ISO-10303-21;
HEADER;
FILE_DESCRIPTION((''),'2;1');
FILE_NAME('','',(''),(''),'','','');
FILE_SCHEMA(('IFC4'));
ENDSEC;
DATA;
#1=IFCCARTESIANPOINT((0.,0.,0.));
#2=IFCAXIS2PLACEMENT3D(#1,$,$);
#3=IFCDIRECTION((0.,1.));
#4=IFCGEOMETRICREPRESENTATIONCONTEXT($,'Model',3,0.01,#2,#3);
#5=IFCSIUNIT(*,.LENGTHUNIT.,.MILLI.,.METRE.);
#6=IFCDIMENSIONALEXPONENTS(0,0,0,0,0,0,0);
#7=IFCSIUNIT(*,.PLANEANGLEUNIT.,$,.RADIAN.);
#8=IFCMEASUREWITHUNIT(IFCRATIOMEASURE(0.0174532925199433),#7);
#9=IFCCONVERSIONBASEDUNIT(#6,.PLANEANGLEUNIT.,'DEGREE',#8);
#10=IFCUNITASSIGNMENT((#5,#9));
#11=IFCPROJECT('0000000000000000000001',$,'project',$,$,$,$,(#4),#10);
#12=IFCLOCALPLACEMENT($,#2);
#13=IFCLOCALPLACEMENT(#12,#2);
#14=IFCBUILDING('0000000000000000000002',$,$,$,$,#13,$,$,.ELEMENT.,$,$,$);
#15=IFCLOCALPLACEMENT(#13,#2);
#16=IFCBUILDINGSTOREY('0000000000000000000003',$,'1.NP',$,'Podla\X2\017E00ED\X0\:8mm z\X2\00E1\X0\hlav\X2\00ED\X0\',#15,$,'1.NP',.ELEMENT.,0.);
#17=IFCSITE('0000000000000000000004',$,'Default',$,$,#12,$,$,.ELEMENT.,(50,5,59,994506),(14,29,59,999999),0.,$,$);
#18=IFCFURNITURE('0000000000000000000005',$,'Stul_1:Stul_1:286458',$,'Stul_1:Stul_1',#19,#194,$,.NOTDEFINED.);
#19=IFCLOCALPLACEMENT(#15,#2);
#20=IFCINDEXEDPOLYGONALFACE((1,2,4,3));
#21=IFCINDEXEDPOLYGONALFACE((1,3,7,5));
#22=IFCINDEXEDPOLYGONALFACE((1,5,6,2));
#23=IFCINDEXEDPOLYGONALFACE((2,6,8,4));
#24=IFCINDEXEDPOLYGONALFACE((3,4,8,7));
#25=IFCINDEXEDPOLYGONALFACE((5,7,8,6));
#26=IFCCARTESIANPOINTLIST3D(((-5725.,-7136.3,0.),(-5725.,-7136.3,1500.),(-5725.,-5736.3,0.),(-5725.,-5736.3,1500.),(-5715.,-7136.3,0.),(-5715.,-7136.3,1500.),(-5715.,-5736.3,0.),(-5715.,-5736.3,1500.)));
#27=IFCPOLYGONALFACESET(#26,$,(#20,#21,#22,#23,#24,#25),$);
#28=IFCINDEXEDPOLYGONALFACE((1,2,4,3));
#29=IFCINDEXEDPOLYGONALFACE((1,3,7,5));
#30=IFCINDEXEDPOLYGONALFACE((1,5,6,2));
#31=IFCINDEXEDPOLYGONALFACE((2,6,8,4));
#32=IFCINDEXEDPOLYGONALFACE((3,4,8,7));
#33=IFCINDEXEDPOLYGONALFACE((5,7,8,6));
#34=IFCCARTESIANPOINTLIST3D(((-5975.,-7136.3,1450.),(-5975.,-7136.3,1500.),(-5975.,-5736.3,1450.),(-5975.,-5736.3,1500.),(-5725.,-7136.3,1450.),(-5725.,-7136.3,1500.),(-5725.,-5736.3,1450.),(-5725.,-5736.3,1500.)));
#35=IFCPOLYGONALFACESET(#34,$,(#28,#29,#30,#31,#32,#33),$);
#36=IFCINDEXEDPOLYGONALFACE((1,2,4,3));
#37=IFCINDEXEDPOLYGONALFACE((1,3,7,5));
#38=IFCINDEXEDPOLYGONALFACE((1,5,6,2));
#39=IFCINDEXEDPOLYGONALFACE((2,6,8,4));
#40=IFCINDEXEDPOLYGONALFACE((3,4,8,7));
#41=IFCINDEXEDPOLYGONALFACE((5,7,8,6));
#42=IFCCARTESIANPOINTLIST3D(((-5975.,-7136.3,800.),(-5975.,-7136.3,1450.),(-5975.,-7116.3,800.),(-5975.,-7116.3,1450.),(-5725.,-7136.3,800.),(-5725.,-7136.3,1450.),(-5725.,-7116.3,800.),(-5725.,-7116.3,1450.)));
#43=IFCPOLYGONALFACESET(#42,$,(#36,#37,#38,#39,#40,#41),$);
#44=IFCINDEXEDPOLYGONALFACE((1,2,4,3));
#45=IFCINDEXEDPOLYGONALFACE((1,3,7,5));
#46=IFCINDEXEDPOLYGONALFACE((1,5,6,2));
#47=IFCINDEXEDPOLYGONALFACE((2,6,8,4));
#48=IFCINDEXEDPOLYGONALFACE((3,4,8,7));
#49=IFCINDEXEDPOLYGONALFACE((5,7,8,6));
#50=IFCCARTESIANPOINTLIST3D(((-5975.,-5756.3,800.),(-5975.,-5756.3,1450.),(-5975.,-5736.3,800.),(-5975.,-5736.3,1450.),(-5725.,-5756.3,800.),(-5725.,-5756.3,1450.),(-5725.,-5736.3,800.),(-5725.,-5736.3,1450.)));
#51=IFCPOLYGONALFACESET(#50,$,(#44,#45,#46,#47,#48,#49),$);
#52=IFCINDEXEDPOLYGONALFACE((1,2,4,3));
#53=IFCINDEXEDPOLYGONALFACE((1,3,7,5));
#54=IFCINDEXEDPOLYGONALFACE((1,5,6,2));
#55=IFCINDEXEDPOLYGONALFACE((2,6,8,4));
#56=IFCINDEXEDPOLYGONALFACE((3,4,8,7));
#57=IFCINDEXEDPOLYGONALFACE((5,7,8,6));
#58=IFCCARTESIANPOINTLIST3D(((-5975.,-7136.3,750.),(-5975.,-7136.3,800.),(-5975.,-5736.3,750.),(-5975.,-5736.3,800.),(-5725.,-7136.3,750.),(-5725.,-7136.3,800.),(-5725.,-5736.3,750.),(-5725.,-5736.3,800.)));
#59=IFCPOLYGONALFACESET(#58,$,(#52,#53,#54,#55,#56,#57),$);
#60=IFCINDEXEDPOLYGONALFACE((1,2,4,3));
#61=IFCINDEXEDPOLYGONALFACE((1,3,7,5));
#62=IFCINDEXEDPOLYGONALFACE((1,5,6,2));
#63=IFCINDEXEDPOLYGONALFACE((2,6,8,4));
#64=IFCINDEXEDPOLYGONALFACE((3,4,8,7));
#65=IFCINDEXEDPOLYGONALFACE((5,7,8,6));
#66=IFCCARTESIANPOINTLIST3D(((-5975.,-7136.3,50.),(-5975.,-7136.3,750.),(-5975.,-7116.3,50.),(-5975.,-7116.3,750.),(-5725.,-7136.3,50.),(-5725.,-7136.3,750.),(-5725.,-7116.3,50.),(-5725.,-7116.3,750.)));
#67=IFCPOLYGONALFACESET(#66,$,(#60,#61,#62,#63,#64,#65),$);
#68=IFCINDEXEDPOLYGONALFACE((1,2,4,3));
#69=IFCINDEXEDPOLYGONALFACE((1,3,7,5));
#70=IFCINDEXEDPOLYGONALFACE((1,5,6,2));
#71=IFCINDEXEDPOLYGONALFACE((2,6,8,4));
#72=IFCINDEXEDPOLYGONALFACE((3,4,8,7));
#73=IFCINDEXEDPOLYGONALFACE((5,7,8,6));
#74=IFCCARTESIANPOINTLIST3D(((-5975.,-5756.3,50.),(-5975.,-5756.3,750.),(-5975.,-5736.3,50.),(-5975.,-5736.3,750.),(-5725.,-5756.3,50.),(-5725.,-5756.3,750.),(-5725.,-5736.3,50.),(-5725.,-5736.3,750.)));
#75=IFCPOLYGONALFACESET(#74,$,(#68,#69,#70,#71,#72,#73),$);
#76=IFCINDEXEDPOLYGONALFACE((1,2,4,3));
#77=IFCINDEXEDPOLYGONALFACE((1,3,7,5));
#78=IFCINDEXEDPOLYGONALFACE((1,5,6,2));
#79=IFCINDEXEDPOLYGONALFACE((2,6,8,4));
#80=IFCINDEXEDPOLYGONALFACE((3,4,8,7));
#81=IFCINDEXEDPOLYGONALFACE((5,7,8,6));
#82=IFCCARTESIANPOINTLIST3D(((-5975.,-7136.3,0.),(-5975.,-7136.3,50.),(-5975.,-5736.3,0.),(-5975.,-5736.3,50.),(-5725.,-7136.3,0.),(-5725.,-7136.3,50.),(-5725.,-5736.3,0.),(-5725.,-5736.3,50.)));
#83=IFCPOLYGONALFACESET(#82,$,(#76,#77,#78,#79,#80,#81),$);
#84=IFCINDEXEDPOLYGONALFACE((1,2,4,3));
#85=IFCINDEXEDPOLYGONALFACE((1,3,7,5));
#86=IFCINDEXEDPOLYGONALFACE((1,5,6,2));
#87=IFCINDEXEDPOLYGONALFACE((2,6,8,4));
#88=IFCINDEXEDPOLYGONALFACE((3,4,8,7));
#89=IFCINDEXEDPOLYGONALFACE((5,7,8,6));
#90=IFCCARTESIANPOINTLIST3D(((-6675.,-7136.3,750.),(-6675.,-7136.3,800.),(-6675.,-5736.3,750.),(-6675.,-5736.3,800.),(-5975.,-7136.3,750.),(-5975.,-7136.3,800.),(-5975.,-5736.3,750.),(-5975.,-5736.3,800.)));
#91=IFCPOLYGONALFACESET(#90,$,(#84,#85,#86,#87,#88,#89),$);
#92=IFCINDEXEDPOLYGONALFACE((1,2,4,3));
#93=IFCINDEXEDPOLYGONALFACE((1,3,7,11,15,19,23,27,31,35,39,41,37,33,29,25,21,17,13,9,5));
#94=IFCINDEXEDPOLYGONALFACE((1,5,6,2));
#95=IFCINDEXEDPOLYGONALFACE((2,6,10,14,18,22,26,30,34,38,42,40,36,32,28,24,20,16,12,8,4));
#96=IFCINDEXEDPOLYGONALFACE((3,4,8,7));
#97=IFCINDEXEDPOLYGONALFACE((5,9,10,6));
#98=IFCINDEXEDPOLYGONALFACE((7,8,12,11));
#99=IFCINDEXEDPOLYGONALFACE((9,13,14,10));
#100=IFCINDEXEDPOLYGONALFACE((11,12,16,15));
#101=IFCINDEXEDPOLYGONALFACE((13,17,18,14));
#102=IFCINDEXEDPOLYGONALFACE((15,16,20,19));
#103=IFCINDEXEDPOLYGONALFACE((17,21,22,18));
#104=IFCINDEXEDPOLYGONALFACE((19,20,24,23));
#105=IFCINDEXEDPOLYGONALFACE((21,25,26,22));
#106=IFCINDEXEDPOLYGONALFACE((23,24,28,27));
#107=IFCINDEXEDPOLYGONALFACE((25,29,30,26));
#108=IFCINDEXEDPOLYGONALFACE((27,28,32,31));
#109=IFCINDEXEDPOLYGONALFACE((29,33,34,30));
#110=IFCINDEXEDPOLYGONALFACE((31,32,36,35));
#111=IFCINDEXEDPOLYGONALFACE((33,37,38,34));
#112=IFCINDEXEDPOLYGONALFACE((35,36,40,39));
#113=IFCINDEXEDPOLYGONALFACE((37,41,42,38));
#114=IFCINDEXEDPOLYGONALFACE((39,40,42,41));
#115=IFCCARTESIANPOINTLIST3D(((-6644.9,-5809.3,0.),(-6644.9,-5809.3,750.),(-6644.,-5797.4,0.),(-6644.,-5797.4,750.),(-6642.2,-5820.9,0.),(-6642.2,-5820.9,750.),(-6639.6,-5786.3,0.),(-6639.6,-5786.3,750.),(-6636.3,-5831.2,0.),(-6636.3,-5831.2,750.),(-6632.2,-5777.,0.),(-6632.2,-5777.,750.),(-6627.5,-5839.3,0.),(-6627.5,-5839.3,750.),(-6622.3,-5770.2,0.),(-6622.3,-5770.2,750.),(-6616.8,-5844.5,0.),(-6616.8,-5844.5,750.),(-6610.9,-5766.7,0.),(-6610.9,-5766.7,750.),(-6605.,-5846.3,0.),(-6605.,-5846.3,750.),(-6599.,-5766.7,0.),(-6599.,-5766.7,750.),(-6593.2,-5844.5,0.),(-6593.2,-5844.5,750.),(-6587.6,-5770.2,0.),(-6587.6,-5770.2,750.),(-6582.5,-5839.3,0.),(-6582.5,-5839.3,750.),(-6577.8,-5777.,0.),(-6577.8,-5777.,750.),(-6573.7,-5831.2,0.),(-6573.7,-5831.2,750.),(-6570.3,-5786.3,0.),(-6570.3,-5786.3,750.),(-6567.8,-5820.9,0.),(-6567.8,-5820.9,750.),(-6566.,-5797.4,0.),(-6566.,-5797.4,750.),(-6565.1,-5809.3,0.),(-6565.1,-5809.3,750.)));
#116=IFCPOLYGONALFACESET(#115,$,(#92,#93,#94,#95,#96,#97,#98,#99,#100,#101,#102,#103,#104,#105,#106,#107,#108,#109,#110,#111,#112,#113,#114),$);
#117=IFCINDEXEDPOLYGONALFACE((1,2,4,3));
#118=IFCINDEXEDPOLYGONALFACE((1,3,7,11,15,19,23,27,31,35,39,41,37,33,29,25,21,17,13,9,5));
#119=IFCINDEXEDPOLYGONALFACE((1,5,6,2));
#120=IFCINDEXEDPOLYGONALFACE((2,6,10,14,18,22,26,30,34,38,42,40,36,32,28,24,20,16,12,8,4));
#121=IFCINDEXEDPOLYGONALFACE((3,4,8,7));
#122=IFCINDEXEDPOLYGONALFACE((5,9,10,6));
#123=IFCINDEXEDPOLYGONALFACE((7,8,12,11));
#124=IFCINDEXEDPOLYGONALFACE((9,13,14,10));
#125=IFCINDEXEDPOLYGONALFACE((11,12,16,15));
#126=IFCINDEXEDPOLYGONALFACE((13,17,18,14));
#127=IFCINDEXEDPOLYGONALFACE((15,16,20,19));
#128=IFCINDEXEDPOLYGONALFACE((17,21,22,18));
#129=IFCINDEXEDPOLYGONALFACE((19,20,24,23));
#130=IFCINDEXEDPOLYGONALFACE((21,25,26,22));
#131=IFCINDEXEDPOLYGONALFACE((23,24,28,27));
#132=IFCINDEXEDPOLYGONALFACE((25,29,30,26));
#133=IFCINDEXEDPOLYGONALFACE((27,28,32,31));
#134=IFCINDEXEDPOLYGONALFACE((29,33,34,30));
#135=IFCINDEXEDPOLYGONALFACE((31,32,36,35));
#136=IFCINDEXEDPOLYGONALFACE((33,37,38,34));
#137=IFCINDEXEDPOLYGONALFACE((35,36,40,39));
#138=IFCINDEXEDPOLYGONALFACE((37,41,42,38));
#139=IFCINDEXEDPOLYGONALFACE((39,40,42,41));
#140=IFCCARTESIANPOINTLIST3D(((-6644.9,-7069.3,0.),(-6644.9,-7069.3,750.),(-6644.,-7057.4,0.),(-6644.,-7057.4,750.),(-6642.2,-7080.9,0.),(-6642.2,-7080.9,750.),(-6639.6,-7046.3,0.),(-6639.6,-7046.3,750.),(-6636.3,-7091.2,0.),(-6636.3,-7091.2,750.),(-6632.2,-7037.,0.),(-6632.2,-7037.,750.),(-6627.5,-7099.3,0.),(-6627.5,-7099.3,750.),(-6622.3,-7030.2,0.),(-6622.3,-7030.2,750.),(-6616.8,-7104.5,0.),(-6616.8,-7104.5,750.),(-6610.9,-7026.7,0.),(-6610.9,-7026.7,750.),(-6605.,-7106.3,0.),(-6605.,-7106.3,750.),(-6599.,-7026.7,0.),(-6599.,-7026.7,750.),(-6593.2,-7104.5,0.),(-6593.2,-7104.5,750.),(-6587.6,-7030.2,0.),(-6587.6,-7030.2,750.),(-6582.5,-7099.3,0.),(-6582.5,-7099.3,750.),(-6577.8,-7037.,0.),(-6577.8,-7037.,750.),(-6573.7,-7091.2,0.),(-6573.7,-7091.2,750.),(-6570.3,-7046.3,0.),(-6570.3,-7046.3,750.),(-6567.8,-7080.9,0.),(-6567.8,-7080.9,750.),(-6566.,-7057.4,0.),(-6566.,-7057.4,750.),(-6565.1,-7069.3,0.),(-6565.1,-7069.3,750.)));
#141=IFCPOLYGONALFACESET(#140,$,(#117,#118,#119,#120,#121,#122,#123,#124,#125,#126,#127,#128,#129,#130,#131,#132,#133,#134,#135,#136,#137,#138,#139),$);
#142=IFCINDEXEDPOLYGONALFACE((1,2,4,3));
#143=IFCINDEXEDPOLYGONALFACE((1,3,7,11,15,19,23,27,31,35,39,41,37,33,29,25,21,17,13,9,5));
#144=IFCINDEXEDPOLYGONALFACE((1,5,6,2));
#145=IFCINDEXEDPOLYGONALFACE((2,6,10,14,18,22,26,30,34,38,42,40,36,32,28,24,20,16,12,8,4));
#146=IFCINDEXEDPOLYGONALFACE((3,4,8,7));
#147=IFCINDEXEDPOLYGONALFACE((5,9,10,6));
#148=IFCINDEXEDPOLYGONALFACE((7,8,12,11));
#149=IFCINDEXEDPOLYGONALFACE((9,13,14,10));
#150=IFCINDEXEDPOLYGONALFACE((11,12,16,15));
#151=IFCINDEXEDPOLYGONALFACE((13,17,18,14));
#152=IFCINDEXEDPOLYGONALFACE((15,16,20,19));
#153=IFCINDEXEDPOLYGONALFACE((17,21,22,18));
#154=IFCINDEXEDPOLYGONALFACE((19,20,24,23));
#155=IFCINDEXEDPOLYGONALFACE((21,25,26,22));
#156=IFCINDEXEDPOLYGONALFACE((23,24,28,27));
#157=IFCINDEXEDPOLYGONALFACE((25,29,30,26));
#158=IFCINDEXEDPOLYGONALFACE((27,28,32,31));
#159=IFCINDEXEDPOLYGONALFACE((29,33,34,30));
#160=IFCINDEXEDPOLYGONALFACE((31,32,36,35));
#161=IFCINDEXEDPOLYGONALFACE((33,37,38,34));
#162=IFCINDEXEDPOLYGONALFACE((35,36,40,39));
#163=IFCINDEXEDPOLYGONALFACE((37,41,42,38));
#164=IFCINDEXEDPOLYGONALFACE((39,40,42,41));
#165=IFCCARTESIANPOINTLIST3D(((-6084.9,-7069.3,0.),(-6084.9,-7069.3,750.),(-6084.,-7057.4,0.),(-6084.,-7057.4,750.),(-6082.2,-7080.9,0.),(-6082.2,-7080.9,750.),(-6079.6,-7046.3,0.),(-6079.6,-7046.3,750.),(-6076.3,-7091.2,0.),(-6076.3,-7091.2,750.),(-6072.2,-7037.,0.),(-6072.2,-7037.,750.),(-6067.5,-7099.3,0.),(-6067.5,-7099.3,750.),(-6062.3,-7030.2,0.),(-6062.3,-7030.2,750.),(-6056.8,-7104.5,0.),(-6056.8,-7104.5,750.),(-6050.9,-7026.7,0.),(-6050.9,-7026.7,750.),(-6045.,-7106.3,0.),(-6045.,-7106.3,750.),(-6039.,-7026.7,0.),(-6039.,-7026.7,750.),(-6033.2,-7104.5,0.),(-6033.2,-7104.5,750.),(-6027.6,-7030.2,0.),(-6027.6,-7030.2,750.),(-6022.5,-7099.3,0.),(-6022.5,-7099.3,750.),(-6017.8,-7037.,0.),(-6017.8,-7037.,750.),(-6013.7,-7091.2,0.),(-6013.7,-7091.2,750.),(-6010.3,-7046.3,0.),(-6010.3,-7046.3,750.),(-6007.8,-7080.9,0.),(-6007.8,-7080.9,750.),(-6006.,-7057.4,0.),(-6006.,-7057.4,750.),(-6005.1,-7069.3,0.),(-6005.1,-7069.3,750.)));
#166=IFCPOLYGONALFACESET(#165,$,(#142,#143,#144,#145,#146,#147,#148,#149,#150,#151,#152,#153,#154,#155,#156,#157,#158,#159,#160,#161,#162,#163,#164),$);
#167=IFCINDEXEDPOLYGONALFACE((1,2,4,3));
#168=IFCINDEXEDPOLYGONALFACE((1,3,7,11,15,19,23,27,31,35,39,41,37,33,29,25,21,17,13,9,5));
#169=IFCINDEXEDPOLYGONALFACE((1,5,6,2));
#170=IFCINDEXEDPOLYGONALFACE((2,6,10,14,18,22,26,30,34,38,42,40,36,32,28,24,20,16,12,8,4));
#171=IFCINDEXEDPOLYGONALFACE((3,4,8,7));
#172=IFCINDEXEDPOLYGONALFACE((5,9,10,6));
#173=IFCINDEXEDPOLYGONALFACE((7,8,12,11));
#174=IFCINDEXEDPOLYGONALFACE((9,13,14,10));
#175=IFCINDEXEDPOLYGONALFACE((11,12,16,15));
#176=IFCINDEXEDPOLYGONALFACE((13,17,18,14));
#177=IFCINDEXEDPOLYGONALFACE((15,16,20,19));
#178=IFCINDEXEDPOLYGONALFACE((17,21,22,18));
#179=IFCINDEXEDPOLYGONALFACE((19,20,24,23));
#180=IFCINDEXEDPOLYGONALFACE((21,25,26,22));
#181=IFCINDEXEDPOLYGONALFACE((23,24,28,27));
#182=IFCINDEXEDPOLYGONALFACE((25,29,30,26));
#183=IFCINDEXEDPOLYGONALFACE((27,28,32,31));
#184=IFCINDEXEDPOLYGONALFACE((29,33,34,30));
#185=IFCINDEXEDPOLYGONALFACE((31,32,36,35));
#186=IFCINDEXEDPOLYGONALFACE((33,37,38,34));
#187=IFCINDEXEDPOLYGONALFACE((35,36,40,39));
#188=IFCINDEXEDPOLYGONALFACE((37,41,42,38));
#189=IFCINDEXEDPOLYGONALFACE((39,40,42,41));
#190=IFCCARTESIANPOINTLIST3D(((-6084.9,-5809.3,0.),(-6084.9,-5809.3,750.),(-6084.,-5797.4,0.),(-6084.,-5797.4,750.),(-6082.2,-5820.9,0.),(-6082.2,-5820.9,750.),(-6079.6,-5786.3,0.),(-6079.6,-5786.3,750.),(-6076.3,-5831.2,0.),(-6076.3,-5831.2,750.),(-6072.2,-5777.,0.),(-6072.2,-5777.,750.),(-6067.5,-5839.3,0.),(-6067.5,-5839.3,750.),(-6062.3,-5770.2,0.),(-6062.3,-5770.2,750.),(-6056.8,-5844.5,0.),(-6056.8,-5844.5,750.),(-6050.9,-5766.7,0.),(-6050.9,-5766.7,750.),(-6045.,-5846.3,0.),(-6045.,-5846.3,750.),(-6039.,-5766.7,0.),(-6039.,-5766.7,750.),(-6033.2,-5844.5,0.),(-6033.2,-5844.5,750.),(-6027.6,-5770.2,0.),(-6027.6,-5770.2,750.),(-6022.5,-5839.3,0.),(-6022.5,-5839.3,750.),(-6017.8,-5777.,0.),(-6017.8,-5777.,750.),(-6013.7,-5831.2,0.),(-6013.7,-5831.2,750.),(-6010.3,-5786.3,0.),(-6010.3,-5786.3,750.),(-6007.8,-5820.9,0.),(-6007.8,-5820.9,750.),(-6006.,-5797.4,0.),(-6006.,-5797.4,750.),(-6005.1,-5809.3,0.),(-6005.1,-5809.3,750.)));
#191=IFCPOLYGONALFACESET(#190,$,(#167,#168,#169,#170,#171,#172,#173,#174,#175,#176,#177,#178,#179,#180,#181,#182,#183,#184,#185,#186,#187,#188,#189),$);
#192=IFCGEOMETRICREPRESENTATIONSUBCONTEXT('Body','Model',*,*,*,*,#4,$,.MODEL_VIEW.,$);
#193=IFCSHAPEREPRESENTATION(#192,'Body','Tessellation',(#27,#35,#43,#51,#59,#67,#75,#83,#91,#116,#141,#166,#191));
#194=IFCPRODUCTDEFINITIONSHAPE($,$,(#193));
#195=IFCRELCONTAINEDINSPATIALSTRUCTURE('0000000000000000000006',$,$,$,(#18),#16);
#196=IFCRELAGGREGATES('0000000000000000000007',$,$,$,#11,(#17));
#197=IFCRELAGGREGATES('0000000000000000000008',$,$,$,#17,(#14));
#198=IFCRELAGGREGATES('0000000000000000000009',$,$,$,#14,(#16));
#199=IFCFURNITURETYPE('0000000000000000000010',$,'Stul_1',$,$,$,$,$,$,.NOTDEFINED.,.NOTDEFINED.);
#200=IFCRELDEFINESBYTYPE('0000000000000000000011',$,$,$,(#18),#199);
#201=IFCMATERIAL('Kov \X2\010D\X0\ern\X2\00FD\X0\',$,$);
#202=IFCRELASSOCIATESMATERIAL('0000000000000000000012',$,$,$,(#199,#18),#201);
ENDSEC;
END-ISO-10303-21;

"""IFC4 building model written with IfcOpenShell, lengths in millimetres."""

from ifc_helpers import new_model, entity, si_unit, converted_unit, direction, frame, frame_2d, origin, origin_2d_with_axis, place, context, subcontext, project, spatial, rectangle, circle, extrude, source, transform, mapped, material, type_object, type_shapes, element, save


model = new_model("IFC4")

# Units and contexts
model_context = context("Model", 3, precision=0.01, world=origin(), true_north=direction((0.0, 1.0)))
body_context = subcontext(model_context, "Body", "Model", "MODEL_VIEW")
ifc_project = project(units=[si_unit("LENGTHUNIT", "METRE", prefix="MILLI"), converted_unit("PLANEANGLEUNIT", "DEGREE", entity("IfcRatioMeasure", 0.0174532925199433), si_unit("PLANEANGLEUNIT", "RADIAN"), dimensions=[0, 0, 0, 0, 0, 0, 0])], contexts=[model_context])

# Site, building, storey
site_placement = place(None, origin())
site = spatial("IfcSite", under=ifc_project, at=site_placement, Name="Default", CompositionType="ELEMENT", RefLatitude=(50, 5, 59, 994506), RefLongitude=(14, 29, 59, 999999), RefElevation=0.0)
building_placement = place(site_placement, origin())
building = spatial("IfcBuilding", under=site, at=building_placement, CompositionType="ELEMENT")
storey_placement = place(building_placement, origin())
storey = spatial("IfcBuildingStorey", under=building, at=storey_placement, Name="1.NP", ObjectType="Podlaží:8mm záhlaví", LongName="1.NP", CompositionType="ELEMENT", Elevation=0.0)

# Furniture
ifc_material_1 = material(Name="Kov černý")
furniture_type = type_object("IfcFurnitureType", Name="Stul_1", AssemblyPlace="NOTDEFINED", PredefinedType="NOTDEFINED", material=ifc_material_1)
shared_shape_1 = source(origin(), body_context, "Body", "SweptSolid", [
    extrude(rectangle(XDim=1400.0, YDim=10.0, at=origin_2d_with_axis()), frame((0.0, 605.0, 0.0), z_axis=(0.0, 0.0, 1.0), x_axis=(-1.0, 0.0, 0.0)), (0.0, 0.0, 1.0), 1500.0),
    extrude(rectangle(XDim=1400.0, YDim=250.0, at=frame_2d((0.0, 0.0), x_axis=(1.0, 0.0))), frame((0.0, 475.0, 1450.0), z_axis=(0.0, 0.0, 1.0), x_axis=(-1.0, 0.0, 0.0)), (0.0, 0.0, 1.0), 50.0),
    extrude(rectangle(XDim=20.0, YDim=250.0, at=origin_2d_with_axis()), frame((690.0, 475.0, 800.0), z_axis=(0.0, 0.0, 1.0), x_axis=(-1.0, 0.0, 0.0)), (0.0, 0.0, 1.0), 650.0),
    extrude(rectangle(XDim=20.0, YDim=250.0, at=frame_2d((0.0, 0.0), x_axis=(1.0, 0.0))), frame((-690.0, 475.0, 800.0), z_axis=(0.0, 0.0, 1.0), x_axis=(-1.0, 0.0, 0.0)), (0.0, 0.0, 1.0), 650.0),
    extrude(rectangle(XDim=1400.0, YDim=250.0, at=origin_2d_with_axis()), frame((0.0, 475.0, 750.0), z_axis=(0.0, 0.0, 1.0), x_axis=(-1.0, 0.0, 0.0)), (0.0, 0.0, 1.0), 50.0),
    extrude(rectangle(XDim=20.0, YDim=250.0, at=origin_2d_with_axis()), frame((690.0, 475.0, 50.0), z_axis=(0.0, 0.0, 1.0), x_axis=(-1.0, 0.0, 0.0)), (0.0, 0.0, 1.0), 700.0),
    extrude(rectangle(XDim=20.0, YDim=250.0, at=frame_2d((0.0, 0.0), x_axis=(1.0, 0.0))), frame((-690.0, 475.0, 50.0), z_axis=(0.0, 0.0, 1.0), x_axis=(-1.0, 0.0, 0.0)), (0.0, 0.0, 1.0), 700.0),
    extrude(rectangle(XDim=1400.0, YDim=250.0, at=origin_2d_with_axis()), frame((0.0, 475.0, 0.0), z_axis=(0.0, 0.0, 1.0), x_axis=(-1.0, 0.0, 0.0)), (0.0, 0.0, 1.0), 50.0),
    extrude(rectangle(XDim=1400.0, YDim=700.0, at=origin_2d_with_axis()), frame((0.0, 0.0, 750.0), z_axis=(0.0, 0.0, 1.0), x_axis=(-1.0, 0.0, 0.0)), (0.0, 0.0, 1.0), 50.0),
    extrude(circle(Radius=40.0, at=frame_2d((0.0, 0.0), x_axis=(1.0, 0.0))), frame((-630.0, -280.0, 0.0)), (0.0, 0.0, 1.0), 750.0),
    extrude(circle(Radius=40.0, at=frame_2d((0.0, 0.0), x_axis=(1.0, 0.0))), frame((630.0, -280.0, 0.0)), (0.0, 0.0, 1.0), 750.0),
    extrude(circle(Radius=40.0, at=frame_2d((0.0, 0.0), x_axis=(1.0, 0.0))), frame((630.0, 280.0, 0.0)), (0.0, 0.0, 1.0), 750.0),
    extrude(circle(Radius=40.0, at=frame_2d((0.0, 0.0), x_axis=(1.0, 0.0))), frame((-630.0, 280.0, 0.0)), (0.0, 0.0, 1.0), 750.0),
])
type_shapes(furniture_type, [shared_shape_1])
for number, where, z_axis, x_axis, name in (
    (1, (-6325.0, -6436.3, 0.0), (0.0, 0.0, 1.0), (0.0, -1.0, 0.0), "Stul_1:Stul_1:286458"),
):
    element("IfcFurniture", number, at=place(storey_placement, frame(where, z_axis=z_axis, x_axis=x_axis)), inside=storey, type_object=furniture_type, material=ifc_material_1, Name=name, ObjectType="Stul_1:Stul_1", PredefinedType="NOTDEFINED", context=body_context, shape_type="MappedRepresentation", body=[
        mapped(shared_shape_1, transform((0.0, 0.0, 0.0), scale=1.0)),
    ])

save(model, "model.ifc")
